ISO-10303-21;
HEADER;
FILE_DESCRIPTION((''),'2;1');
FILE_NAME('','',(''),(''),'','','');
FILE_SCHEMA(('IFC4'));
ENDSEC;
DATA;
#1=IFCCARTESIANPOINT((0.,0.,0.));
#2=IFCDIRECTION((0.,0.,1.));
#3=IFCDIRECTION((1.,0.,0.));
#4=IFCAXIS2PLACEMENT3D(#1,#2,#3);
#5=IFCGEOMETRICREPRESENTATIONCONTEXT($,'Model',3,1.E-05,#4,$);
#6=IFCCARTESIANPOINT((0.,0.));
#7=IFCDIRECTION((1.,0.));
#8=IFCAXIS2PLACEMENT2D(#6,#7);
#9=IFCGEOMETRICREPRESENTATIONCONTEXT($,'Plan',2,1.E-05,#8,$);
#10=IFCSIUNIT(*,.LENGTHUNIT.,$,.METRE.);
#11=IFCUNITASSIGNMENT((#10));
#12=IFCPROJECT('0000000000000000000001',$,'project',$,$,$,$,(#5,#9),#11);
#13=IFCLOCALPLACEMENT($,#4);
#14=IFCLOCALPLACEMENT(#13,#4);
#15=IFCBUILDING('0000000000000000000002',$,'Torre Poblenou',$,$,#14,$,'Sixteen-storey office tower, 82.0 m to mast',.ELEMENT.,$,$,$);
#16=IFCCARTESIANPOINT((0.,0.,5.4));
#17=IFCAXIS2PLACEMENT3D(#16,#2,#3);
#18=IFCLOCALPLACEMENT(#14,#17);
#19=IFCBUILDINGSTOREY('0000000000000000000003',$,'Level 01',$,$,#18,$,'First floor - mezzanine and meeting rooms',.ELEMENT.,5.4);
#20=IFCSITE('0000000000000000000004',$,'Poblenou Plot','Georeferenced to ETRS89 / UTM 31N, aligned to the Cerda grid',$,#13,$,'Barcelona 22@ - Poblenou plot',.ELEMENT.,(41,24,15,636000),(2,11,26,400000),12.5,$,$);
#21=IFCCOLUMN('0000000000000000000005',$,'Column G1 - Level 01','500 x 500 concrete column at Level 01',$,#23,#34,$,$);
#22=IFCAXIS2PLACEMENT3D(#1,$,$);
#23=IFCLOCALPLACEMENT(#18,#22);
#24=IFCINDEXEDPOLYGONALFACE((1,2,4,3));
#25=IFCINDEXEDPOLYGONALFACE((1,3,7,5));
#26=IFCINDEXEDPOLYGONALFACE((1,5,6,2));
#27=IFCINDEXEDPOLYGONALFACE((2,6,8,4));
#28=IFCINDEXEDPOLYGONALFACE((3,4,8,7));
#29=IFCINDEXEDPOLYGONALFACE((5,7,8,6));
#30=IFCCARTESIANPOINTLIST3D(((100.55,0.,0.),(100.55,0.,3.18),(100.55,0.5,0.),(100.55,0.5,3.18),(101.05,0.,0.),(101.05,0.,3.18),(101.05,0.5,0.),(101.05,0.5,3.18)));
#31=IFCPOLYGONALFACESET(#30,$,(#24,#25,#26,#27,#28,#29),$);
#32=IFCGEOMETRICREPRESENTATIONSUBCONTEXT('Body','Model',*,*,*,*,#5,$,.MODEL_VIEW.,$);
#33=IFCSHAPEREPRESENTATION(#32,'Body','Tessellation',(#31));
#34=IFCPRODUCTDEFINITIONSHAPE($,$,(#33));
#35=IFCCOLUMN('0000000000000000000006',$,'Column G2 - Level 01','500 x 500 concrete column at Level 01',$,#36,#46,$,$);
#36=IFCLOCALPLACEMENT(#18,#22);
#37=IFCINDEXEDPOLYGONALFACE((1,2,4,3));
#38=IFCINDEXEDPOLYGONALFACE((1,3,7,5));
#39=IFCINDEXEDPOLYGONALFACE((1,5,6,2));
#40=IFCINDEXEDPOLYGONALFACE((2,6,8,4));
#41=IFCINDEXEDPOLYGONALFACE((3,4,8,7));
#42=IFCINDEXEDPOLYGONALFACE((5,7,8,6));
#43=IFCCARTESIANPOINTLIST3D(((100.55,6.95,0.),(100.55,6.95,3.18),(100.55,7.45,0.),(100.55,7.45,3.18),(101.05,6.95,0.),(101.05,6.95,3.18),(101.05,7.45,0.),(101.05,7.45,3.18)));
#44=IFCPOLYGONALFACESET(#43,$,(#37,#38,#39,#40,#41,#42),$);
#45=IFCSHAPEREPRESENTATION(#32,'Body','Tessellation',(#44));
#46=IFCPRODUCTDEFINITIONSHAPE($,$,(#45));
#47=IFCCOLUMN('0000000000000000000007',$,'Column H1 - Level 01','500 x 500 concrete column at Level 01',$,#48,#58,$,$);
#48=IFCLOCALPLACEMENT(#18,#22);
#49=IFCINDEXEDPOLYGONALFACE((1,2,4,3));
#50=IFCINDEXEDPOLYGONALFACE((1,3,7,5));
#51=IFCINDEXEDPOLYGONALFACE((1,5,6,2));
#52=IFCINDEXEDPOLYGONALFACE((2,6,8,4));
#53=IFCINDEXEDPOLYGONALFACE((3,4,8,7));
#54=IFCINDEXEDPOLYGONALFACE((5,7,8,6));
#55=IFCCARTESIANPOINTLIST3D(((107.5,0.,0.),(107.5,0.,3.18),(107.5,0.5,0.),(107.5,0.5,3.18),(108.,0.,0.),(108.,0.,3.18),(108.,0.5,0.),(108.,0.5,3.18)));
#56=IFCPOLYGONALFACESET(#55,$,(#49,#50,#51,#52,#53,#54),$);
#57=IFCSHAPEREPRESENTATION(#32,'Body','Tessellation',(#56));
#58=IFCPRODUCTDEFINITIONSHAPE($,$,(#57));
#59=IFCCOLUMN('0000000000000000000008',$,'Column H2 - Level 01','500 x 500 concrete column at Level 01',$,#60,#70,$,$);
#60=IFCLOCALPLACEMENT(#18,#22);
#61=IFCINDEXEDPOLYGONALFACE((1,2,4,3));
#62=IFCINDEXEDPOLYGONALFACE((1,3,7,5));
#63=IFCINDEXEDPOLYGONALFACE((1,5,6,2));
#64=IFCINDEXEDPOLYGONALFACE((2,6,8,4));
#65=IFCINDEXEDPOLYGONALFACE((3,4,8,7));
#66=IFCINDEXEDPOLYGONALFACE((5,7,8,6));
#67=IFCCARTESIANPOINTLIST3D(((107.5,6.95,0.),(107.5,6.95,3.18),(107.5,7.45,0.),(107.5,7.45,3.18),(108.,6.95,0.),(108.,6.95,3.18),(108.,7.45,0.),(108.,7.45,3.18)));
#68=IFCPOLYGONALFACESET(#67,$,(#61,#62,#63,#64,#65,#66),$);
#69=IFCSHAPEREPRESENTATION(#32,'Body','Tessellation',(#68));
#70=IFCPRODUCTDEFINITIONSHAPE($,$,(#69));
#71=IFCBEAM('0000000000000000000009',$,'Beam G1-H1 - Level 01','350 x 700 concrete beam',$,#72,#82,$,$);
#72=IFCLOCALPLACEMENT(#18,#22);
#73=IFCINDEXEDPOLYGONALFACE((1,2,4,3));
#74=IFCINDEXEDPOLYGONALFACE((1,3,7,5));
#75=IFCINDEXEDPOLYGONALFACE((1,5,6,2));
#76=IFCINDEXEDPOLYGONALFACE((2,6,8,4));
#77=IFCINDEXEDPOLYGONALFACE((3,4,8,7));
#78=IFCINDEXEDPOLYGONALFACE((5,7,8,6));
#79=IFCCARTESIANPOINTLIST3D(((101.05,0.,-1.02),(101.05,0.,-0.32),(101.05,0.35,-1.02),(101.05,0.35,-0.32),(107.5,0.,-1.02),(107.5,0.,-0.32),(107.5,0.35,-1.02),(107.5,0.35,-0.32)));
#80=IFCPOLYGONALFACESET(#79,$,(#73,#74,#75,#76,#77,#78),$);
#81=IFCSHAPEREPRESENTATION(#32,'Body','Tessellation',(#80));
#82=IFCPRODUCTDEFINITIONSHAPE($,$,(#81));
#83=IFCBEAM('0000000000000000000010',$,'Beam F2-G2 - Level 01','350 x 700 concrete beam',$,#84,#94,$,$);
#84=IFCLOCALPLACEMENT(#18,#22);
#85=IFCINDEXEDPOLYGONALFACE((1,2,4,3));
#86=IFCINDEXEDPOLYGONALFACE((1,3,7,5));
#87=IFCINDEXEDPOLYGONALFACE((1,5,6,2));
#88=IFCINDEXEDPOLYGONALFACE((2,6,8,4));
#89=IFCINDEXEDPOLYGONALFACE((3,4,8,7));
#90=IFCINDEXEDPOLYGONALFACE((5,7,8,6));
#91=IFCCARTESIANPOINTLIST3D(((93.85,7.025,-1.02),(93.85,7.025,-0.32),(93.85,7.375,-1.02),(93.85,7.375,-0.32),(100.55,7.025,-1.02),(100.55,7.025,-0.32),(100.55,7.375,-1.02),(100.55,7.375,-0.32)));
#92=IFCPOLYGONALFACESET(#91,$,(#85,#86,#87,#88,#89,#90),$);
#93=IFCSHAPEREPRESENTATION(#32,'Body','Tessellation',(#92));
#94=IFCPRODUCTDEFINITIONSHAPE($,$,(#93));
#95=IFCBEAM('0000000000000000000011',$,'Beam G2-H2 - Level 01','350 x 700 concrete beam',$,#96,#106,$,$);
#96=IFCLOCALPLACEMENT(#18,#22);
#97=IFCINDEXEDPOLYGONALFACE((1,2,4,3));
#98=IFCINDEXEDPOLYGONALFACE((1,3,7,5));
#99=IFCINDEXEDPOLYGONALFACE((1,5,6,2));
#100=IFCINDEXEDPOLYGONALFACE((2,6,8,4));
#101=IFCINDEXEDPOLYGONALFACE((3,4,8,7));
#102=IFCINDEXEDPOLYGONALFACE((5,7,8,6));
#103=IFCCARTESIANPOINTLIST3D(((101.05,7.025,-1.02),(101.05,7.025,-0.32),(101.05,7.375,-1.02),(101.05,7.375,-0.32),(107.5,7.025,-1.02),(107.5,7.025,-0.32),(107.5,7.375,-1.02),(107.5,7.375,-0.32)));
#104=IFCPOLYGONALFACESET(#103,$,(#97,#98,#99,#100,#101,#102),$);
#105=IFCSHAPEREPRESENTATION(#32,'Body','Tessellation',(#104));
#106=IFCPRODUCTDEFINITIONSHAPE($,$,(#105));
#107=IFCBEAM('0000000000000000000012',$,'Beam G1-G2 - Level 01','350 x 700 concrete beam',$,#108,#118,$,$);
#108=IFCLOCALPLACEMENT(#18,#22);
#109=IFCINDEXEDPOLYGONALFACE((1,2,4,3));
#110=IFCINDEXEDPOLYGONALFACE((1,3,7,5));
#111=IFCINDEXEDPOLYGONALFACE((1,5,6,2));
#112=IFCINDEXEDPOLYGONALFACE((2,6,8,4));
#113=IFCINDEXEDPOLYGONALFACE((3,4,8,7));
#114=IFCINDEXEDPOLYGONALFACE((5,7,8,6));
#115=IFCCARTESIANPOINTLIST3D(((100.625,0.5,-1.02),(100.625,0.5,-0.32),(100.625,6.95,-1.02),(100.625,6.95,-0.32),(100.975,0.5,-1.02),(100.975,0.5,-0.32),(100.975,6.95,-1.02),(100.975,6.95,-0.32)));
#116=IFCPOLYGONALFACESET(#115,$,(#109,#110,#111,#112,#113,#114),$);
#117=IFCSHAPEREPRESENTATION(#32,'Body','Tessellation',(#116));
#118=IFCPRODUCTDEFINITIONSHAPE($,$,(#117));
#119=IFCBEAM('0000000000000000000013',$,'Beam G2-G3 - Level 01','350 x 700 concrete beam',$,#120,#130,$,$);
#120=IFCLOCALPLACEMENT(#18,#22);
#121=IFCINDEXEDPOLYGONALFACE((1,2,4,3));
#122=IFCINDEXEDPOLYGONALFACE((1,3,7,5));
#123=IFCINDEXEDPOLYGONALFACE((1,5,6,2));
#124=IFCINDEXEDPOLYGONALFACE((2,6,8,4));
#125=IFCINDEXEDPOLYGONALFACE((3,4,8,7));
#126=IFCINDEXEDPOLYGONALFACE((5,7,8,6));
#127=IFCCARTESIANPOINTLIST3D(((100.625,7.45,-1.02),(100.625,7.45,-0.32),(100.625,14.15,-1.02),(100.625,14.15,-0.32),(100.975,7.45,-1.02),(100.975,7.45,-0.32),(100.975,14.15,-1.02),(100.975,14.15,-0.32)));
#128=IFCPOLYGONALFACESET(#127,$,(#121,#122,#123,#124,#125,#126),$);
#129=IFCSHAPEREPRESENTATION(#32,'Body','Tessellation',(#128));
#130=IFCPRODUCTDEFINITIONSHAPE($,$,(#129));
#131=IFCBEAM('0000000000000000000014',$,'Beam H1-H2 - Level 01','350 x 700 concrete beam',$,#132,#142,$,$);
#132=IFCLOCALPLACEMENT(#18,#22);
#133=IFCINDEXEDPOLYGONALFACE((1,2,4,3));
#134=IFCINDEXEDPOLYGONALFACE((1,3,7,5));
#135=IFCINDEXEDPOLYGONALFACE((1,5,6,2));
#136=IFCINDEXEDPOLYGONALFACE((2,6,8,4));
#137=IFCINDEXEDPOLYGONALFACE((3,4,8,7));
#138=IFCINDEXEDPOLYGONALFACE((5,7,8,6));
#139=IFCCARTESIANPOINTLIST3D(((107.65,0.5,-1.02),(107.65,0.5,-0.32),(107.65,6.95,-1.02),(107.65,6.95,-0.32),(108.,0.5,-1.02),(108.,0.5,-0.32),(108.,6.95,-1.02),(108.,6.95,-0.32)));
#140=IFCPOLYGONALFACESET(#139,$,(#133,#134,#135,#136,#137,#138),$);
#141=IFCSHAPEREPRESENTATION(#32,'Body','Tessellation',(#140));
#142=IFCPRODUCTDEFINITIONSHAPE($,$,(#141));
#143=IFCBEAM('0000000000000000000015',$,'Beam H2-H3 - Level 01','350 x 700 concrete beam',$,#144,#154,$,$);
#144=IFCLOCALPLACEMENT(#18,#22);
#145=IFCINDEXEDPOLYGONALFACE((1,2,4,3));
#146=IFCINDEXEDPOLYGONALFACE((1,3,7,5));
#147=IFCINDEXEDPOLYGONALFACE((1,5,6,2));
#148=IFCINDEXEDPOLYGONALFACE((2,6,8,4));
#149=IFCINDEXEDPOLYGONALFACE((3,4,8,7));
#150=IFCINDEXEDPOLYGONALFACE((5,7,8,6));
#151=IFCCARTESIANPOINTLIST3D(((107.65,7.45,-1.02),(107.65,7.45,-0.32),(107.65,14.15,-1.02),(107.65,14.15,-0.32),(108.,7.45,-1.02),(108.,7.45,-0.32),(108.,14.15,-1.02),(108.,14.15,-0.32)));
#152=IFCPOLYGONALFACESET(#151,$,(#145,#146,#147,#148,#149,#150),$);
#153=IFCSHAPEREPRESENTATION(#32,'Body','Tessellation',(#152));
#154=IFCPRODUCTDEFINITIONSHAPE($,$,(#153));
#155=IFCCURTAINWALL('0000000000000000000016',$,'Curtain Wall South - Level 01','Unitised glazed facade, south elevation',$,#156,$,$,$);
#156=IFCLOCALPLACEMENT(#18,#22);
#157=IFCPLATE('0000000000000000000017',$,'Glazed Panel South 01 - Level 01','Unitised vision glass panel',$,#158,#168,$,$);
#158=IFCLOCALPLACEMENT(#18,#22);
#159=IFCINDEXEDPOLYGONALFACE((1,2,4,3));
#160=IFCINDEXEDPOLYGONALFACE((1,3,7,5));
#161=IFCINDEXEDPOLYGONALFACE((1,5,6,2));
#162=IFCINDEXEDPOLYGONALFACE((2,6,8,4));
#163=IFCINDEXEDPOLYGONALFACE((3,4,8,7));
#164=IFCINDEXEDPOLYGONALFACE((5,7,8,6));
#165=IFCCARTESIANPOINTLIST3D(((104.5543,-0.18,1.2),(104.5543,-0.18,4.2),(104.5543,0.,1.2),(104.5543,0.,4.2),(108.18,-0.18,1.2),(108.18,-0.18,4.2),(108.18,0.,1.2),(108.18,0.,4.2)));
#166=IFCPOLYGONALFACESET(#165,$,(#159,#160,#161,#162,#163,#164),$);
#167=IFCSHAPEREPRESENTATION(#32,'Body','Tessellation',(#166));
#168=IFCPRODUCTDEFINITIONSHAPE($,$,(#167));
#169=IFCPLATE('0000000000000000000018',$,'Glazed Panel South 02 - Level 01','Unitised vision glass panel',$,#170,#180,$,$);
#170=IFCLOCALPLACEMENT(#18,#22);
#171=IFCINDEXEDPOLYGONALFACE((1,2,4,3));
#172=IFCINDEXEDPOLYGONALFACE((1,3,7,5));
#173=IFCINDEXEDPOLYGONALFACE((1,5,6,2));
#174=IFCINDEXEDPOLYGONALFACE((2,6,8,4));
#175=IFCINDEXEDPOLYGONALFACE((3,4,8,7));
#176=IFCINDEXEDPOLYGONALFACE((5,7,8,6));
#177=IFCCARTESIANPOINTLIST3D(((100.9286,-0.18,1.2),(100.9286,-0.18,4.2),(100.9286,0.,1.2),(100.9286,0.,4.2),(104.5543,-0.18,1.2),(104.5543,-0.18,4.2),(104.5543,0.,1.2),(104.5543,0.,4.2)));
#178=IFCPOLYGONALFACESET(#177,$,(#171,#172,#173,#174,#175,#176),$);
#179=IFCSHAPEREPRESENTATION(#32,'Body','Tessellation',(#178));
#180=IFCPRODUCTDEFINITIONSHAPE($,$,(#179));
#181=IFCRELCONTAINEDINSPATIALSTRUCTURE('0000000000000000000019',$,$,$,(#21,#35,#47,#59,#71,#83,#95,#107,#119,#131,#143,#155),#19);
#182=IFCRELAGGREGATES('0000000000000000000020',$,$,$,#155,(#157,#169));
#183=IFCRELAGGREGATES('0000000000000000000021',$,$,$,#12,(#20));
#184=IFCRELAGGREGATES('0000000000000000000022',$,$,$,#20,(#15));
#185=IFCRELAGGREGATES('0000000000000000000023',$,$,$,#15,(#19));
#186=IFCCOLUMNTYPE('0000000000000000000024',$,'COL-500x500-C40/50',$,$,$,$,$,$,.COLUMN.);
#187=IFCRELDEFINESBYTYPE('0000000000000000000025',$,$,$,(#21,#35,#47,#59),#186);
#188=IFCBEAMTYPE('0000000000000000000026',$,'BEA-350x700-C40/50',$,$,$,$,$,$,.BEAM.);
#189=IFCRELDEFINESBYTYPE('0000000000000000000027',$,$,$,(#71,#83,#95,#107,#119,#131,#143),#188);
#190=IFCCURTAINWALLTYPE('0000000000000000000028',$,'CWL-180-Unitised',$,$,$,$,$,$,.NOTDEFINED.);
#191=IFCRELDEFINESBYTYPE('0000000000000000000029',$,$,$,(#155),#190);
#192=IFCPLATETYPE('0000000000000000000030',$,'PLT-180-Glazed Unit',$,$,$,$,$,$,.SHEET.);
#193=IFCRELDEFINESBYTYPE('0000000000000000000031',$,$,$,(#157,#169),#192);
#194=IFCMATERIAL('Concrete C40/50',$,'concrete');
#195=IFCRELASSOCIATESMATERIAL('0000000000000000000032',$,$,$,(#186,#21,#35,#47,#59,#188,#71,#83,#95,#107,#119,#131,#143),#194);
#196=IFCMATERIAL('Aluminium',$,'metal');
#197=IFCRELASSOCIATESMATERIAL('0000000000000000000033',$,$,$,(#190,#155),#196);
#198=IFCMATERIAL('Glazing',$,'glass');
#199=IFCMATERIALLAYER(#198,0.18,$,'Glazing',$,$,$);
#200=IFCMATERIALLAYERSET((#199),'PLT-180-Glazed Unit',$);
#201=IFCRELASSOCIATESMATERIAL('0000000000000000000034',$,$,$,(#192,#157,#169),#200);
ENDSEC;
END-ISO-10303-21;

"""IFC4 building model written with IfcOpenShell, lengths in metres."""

from ifc_helpers import new_model, si_unit, frame, origin_with_axes, origin_2d_with_axis, place, context, subcontext, project, spatial, line, indexed_curve, rectangle, outline, extrude, material, layer, layer_set, layer_usage, material_profile, profile_set, profile_usage, type_object, element, aggregate, save


model = new_model("IFC4")

# Units and contexts
model_context = context("Model", 3, precision=1e-05, world=origin_with_axes())
plan_context = context("Plan", 2, precision=1e-05, world=origin_2d_with_axis())
body_context = subcontext(model_context, "Body", "Model", "MODEL_VIEW")
ifc_project = project(units=[si_unit("LENGTHUNIT", "METRE")], contexts=[model_context, plan_context])

# Site, building, storey
site_placement = place(None, origin_with_axes())
site = spatial("IfcSite", under=ifc_project, at=site_placement, Name="Poblenou Plot", Description="Georeferenced to ETRS89 / UTM 31N, aligned to the Cerda grid", LongName="Barcelona 22@ - Poblenou plot", CompositionType="ELEMENT", RefLatitude=(41, 24, 15, 636000), RefLongitude=(2, 11, 26, 400000), RefElevation=12.5)
building_placement = place(site_placement, origin_with_axes())
building = spatial("IfcBuilding", under=site, at=building_placement, Name="Torre Poblenou", LongName="Sixteen-storey office tower, 82.0 m to mast", CompositionType="ELEMENT")
storey_placement = place(building_placement, frame((0.0, 0.0, 5.4), z_axis=(0.0, 0.0, 1.0), x_axis=(1.0, 0.0, 0.0)))
storey = spatial("IfcBuildingStorey", under=building, at=storey_placement, Name="Level 01", LongName="First floor - mezzanine and meeting rooms", CompositionType="ELEMENT", Elevation=5.4)

# Columns
ifc_material_1 = material(Name="Concrete C40/50", Category="concrete")
ifc_material_profile_1 = material_profile(ifc_material_1, rectangle(XDim=0.5, YDim=0.5))
ifc_profile_set_1 = profile_set([ifc_material_profile_1], Name="COL-500x500-C40/50")
ifc_profile_usage_1 = profile_usage(ifc_profile_set_1)
column_type = type_object("IfcColumnType", Name="COL-500x500-C40/50", PredefinedType="COLUMN", material=ifc_profile_set_1)
column_1_placement = place(storey_placement, frame((100.55, 0.0, 0.0), z_axis=(0.0, 0.0, 1.0), x_axis=(1.0, 0.0, 0.0)))
element("IfcColumn", 1, at=column_1_placement, inside=storey, type_object=column_type, material=ifc_profile_usage_1, Name="Column G1 - Level 01", Description="500 x 500 concrete column at Level 01", context=body_context, shape_type="SweptSolid", body=[
    extrude(outline(indexed_curve([(0.0, 0.0), (0.5, 0.0), (0.5, 0.5), (0.0, 0.5)], segments=[line(1, 2, 3, 4, 1)])), origin_with_axes(), (0.0, 0.0, 1.0), 3.18),
])
ifc_profile_usage_2 = profile_usage(ifc_profile_set_1)
column_2_placement = place(storey_placement, frame((100.55, 6.95, 0.0), z_axis=(0.0, 0.0, 1.0), x_axis=(1.0, 0.0, 0.0)))
element("IfcColumn", 2, at=column_2_placement, inside=storey, type_object=column_type, material=ifc_profile_usage_2, Name="Column G2 - Level 01", Description="500 x 500 concrete column at Level 01", context=body_context, shape_type="SweptSolid", body=[
    extrude(outline(indexed_curve([(0.0, 0.0), (0.5, 0.0), (0.5, 0.5), (0.0, 0.5)], segments=[line(1, 2, 3, 4, 1)])), origin_with_axes(), (0.0, 0.0, 1.0), 3.18),
])
ifc_profile_usage_3 = profile_usage(ifc_profile_set_1)
column_3_placement = place(storey_placement, frame((107.5, 0.0, 0.0), z_axis=(0.0, 0.0, 1.0), x_axis=(1.0, 0.0, 0.0)))
element("IfcColumn", 3, at=column_3_placement, inside=storey, type_object=column_type, material=ifc_profile_usage_3, Name="Column H1 - Level 01", Description="500 x 500 concrete column at Level 01", context=body_context, shape_type="SweptSolid", body=[
    extrude(outline(indexed_curve([(0.0, 0.0), (0.5, 0.0), (0.5, 0.5), (0.0, 0.5)], segments=[line(1, 2, 3, 4, 1)])), origin_with_axes(), (0.0, 0.0, 1.0), 3.18),
])
ifc_profile_usage_4 = profile_usage(ifc_profile_set_1)
column_4_placement = place(storey_placement, frame((107.5, 6.95, 0.0), z_axis=(0.0, 0.0, 1.0), x_axis=(1.0, 0.0, 0.0)))
element("IfcColumn", 4, at=column_4_placement, inside=storey, type_object=column_type, material=ifc_profile_usage_4, Name="Column H2 - Level 01", Description="500 x 500 concrete column at Level 01", context=body_context, shape_type="SweptSolid", body=[
    extrude(outline(indexed_curve([(0.0, 0.0), (0.5, 0.0), (0.5, 0.5), (0.0, 0.5)], segments=[line(1, 2, 3, 4, 1)])), origin_with_axes(), (0.0, 0.0, 1.0), 3.18),
])

# Beams
ifc_material_profile_2 = material_profile(ifc_material_1, rectangle(XDim=0.35, YDim=0.7))
ifc_profile_set_2 = profile_set([ifc_material_profile_2], Name="BEA-350x700-C40/50")
ifc_profile_usage_5 = profile_usage(ifc_profile_set_2)
beam_type = type_object("IfcBeamType", Name="BEA-350x700-C40/50", PredefinedType="BEAM", material=ifc_profile_set_2)
beam_1_placement = place(storey_placement, frame((101.05, 0.0, -1.02), z_axis=(0.0, 0.0, 1.0), x_axis=(1.0, 0.0, 0.0)))
element("IfcBeam", 5, at=beam_1_placement, inside=storey, type_object=beam_type, material=ifc_profile_usage_5, Name="Beam G1-H1 - Level 01", Description="350 x 700 concrete beam", context=body_context, shape_type="SweptSolid", body=[
    extrude(outline(indexed_curve([(0.0, 0.0), (6.45, 0.0), (6.45, 0.35), (0.0, 0.35)], segments=[line(1, 2, 3, 4, 1)])), origin_with_axes(), (0.0, 0.0, 1.0), 0.7),
])
ifc_profile_usage_6 = profile_usage(ifc_profile_set_2)
beam_2_placement = place(storey_placement, frame((93.85, 7.025, -1.02), z_axis=(0.0, 0.0, 1.0), x_axis=(1.0, 0.0, 0.0)))
element("IfcBeam", 6, at=beam_2_placement, inside=storey, type_object=beam_type, material=ifc_profile_usage_6, Name="Beam F2-G2 - Level 01", Description="350 x 700 concrete beam", context=body_context, shape_type="SweptSolid", body=[
    extrude(outline(indexed_curve([(0.0, 0.0), (6.7, 0.0), (6.7, 0.35), (0.0, 0.35)], segments=[line(1, 2, 3, 4, 1)])), origin_with_axes(), (0.0, 0.0, 1.0), 0.7),
])
ifc_profile_usage_7 = profile_usage(ifc_profile_set_2)
beam_3_placement = place(storey_placement, frame((101.05, 7.025, -1.02), z_axis=(0.0, 0.0, 1.0), x_axis=(1.0, 0.0, 0.0)))
element("IfcBeam", 7, at=beam_3_placement, inside=storey, type_object=beam_type, material=ifc_profile_usage_7, Name="Beam G2-H2 - Level 01", Description="350 x 700 concrete beam", context=body_context, shape_type="SweptSolid", body=[
    extrude(outline(indexed_curve([(0.0, 0.0), (6.45, 0.0), (6.45, 0.35), (0.0, 0.35)], segments=[line(1, 2, 3, 4, 1)])), origin_with_axes(), (0.0, 0.0, 1.0), 0.7),
])
ifc_profile_usage_8 = profile_usage(ifc_profile_set_2)
beam_4_placement = place(storey_placement, frame((100.975, 0.5, -1.02), z_axis=(0.0, 0.0, 1.0), x_axis=(0.0, 1.0, 0.0)))
element("IfcBeam", 8, at=beam_4_placement, inside=storey, type_object=beam_type, material=ifc_profile_usage_8, Name="Beam G1-G2 - Level 01", Description="350 x 700 concrete beam", context=body_context, shape_type="SweptSolid", body=[
    extrude(outline(indexed_curve([(0.0, 0.0), (6.45, 0.0), (6.45, 0.35), (0.0, 0.35)], segments=[line(1, 2, 3, 4, 1)])), origin_with_axes(), (0.0, 0.0, 1.0), 0.7),
])
ifc_profile_usage_9 = profile_usage(ifc_profile_set_2)
beam_5_placement = place(storey_placement, frame((100.975, 7.45, -1.02), z_axis=(0.0, 0.0, 1.0), x_axis=(0.0, 1.0, 0.0)))
element("IfcBeam", 9, at=beam_5_placement, inside=storey, type_object=beam_type, material=ifc_profile_usage_9, Name="Beam G2-G3 - Level 01", Description="350 x 700 concrete beam", context=body_context, shape_type="SweptSolid", body=[
    extrude(outline(indexed_curve([(0.0, 0.0), (6.7, 0.0), (6.7, 0.35), (0.0, 0.35)], segments=[line(1, 2, 3, 4, 1)])), origin_with_axes(), (0.0, 0.0, 1.0), 0.7),
])
ifc_profile_usage_10 = profile_usage(ifc_profile_set_2)
beam_6_placement = place(storey_placement, frame((108.0, 0.5, -1.02), z_axis=(0.0, 0.0, 1.0), x_axis=(0.0, 1.0, 0.0)))
element("IfcBeam", 10, at=beam_6_placement, inside=storey, type_object=beam_type, material=ifc_profile_usage_10, Name="Beam H1-H2 - Level 01", Description="350 x 700 concrete beam", context=body_context, shape_type="SweptSolid", body=[
    extrude(outline(indexed_curve([(0.0, 0.0), (6.45, 0.0), (6.45, 0.35), (0.0, 0.35)], segments=[line(1, 2, 3, 4, 1)])), origin_with_axes(), (0.0, 0.0, 1.0), 0.7),
])
ifc_profile_usage_11 = profile_usage(ifc_profile_set_2)
beam_7_placement = place(storey_placement, frame((108.0, 7.45, -1.02), z_axis=(0.0, 0.0, 1.0), x_axis=(0.0, 1.0, 0.0)))
element("IfcBeam", 11, at=beam_7_placement, inside=storey, type_object=beam_type, material=ifc_profile_usage_11, Name="Beam H2-H3 - Level 01", Description="350 x 700 concrete beam", context=body_context, shape_type="SweptSolid", body=[
    extrude(outline(indexed_curve([(0.0, 0.0), (6.7, 0.0), (6.7, 0.35), (0.0, 0.35)], segments=[line(1, 2, 3, 4, 1)])), origin_with_axes(), (0.0, 0.0, 1.0), 0.7),
])

# Curtain wall, plates
ifc_material_2 = material(Name="Aluminium", Category="metal")
curtain_wall_type = type_object("IfcCurtainWallType", Name="CWL-180-Unitised", PredefinedType="NOTDEFINED", material=ifc_material_2)
curtain_wall_1_placement = place(storey_placement, frame((108.18, 0.0, 0.0), z_axis=(0.0, 0.0, 1.0), x_axis=(-1.0, 0.0, 0.0)))
curtain_wall_1 = element("IfcCurtainWall", 12, at=curtain_wall_1_placement, inside=storey, type_object=curtain_wall_type, material=ifc_material_2, Name="Curtain Wall South - Level 01", Description="Unitised glazed facade, south elevation")
ifc_material_3 = material(Name="Glazing", Category="glass")
ifc_layer_1 = layer(ifc_material_3, 0.18, Name="Glazing")
ifc_layer_set_1 = layer_set([ifc_layer_1], Name="PLT-180-Glazed Unit")
ifc_layer_usage_1 = layer_usage(ifc_layer_set_1, "AXIS2", "POSITIVE", 0.0)
plate_type_1 = type_object("IfcPlateType", Name="PLT-180-Glazed Unit", PredefinedType="SHEET", material=ifc_layer_set_1)
plate_1_placement = place(curtain_wall_1_placement, frame((0.0, 0.0, 1.2), z_axis=(0.0, 0.0, 1.0), x_axis=(1.0, 0.0, 0.0)))
plate_1 = element("IfcPlate", 13, at=plate_1_placement, type_object=plate_type_1, material=ifc_layer_usage_1, Name="Glazed Panel South 01 - Level 01", Description="Unitised vision glass panel", context=body_context, shape_type="SweptSolid", body=[
    extrude(outline(indexed_curve([(0.0, 0.0), (3.6257, 0.0), (3.6257, 0.18), (0.0, 0.18)], segments=[line(1, 2, 3, 4, 1)])), origin_with_axes(), (0.0, 0.0, 1.0), 3.0),
])
ifc_layer_usage_2 = layer_usage(ifc_layer_set_1, "AXIS2", "POSITIVE", 0.0)
plate_2_placement = place(curtain_wall_1_placement, frame((3.6257, 0.0, 1.2), z_axis=(0.0, 0.0, 1.0), x_axis=(1.0, 0.0, 0.0)))
plate_2 = element("IfcPlate", 14, at=plate_2_placement, type_object=plate_type_1, material=ifc_layer_usage_2, Name="Glazed Panel South 02 - Level 01", Description="Unitised vision glass panel", context=body_context, shape_type="SweptSolid", body=[
    extrude(outline(indexed_curve([(0.0, 0.0), (3.6257, 0.0), (3.6257, 0.18), (0.0, 0.18)], segments=[line(1, 2, 3, 4, 1)])), origin_with_axes(), (0.0, 0.0, 1.0), 3.0),
])

aggregate(curtain_wall_1, [plate_1, plate_2])

save(model, "model.ifc")
